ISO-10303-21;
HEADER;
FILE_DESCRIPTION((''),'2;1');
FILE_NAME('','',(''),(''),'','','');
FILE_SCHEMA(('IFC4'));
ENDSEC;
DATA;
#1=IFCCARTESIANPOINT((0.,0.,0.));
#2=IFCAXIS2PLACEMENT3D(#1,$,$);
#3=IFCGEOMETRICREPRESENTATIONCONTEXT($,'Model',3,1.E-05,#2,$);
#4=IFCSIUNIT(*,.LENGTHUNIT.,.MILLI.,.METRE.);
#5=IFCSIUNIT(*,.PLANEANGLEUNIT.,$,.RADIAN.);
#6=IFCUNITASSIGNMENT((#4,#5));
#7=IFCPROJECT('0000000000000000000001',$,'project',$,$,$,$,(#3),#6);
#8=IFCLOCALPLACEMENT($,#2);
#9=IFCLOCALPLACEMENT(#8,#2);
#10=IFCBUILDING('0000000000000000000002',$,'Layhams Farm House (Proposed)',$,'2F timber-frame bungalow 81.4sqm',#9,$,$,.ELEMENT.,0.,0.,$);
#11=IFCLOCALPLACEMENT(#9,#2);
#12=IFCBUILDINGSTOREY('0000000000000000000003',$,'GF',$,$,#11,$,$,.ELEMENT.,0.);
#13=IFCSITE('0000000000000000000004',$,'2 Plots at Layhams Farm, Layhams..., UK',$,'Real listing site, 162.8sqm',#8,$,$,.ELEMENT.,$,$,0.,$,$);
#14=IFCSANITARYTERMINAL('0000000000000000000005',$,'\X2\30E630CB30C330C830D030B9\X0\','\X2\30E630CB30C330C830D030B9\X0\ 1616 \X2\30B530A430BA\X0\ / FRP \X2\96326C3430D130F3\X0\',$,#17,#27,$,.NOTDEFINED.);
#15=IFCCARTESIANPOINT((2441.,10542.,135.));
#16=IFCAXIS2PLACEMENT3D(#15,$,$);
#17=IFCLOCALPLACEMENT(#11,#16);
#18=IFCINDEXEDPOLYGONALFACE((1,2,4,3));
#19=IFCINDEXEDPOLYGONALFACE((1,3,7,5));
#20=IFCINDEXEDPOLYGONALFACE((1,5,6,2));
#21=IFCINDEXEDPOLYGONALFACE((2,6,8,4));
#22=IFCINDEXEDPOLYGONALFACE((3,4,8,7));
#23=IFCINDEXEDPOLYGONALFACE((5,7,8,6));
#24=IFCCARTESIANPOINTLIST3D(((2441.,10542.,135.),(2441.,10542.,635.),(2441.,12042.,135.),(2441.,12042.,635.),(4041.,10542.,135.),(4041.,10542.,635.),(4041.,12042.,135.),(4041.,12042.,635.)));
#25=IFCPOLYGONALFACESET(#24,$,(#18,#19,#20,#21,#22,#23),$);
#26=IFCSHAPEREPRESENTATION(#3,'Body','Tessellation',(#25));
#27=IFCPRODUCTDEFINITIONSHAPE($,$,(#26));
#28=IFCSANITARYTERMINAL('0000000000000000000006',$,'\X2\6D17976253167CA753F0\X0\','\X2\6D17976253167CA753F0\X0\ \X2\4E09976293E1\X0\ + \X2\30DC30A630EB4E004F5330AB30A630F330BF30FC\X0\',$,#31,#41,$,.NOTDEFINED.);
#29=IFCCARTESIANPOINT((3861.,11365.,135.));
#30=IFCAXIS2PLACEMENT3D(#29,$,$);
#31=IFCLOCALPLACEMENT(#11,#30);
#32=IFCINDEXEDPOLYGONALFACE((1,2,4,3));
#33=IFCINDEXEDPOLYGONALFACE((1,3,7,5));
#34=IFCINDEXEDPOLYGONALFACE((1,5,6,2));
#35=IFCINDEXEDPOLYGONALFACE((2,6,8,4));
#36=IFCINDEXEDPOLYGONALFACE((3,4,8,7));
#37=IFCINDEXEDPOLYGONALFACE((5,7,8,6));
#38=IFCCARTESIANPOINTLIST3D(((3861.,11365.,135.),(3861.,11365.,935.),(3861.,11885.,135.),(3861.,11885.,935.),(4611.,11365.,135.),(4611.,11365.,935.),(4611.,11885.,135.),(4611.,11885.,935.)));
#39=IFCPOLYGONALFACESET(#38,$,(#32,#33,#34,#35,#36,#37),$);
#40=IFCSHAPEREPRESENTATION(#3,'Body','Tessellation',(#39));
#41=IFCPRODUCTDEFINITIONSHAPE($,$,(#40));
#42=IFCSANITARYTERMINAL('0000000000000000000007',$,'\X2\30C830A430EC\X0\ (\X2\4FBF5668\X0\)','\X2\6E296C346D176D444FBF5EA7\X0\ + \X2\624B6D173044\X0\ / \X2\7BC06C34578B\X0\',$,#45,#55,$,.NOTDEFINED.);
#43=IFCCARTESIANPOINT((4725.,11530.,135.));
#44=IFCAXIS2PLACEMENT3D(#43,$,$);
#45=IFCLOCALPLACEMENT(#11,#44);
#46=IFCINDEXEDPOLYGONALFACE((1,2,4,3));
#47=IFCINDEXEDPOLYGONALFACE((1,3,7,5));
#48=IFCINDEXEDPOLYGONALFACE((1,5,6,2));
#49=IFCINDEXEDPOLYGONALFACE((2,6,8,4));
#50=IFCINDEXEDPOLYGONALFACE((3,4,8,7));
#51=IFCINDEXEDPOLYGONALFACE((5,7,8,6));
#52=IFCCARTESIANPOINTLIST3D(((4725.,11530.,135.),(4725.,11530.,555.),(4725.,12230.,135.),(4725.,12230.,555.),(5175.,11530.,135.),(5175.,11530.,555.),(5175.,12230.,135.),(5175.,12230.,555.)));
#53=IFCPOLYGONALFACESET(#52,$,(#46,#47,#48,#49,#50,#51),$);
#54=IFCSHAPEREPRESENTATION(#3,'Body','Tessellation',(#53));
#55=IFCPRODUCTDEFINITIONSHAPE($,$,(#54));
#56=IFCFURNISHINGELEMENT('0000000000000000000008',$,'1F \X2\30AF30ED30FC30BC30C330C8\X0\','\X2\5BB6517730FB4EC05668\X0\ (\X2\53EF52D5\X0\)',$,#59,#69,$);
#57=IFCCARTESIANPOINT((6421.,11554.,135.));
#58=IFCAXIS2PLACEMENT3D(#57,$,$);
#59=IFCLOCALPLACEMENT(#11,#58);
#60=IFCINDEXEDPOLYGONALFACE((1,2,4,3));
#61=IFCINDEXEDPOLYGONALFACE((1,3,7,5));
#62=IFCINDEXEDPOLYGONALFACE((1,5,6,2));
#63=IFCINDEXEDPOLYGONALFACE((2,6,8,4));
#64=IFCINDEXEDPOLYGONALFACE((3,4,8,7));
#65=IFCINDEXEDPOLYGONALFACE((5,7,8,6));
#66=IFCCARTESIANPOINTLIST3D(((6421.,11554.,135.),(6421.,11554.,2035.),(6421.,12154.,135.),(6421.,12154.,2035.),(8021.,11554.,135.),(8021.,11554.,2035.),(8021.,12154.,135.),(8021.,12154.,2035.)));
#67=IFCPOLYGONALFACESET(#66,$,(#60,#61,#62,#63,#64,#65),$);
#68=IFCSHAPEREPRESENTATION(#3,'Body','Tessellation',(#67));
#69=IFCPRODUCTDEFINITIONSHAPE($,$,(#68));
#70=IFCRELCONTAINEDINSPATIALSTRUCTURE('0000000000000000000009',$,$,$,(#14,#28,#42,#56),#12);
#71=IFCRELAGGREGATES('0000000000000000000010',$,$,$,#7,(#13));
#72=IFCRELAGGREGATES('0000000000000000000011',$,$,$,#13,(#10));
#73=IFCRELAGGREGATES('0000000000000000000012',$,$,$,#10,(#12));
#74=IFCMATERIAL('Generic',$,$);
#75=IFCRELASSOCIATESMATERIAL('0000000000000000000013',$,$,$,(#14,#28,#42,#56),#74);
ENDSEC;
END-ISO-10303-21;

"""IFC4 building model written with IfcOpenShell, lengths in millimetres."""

from ifc_helpers import new_model, si_unit, frame, frame_2d, origin, place, context, project, spatial, rectangle, extrude, material, element, save


model = new_model("IFC4")

# Units and contexts
model_context = context("Model", 3, precision=1e-05, world=origin())
ifc_project = project(units=[si_unit("LENGTHUNIT", "METRE", prefix="MILLI"), si_unit("PLANEANGLEUNIT", "RADIAN")], contexts=[model_context])

# Site, building, storey
site_placement = place(None, origin())
site = spatial("IfcSite", under=ifc_project, at=site_placement, Name="2 Plots at Layhams Farm, Layhams..., UK", ObjectType="Real listing site, 162.8sqm", CompositionType="ELEMENT", RefElevation=0.0)
building_placement = place(site_placement, origin())
building = spatial("IfcBuilding", under=site, at=building_placement, Name="Layhams Farm House (Proposed)", ObjectType="2F timber-frame bungalow 81.4sqm", CompositionType="ELEMENT", ElevationOfRefHeight=0.0, ElevationOfTerrain=0.0)
storey_placement = place(building_placement, origin())
storey = spatial("IfcBuildingStorey", under=building, at=storey_placement, Name="GF", CompositionType="ELEMENT", Elevation=0.0)

# Shared definitions
ifc_material_1 = material(Name="Generic")

# Sanitary terminals
sanitary_terminal_1_placement = place(storey_placement, frame((2441.0, 10542.0, 135.0)))
element("IfcSanitaryTerminal", 1, at=sanitary_terminal_1_placement, inside=storey, material=ifc_material_1, Name="ユニットバス", Description="ユニットバス 1616 サイズ / FRP 防水パン", PredefinedType="NOTDEFINED", context=model_context, shape_type="SweptSolid", body=[
    extrude(rectangle(XDim=1600.0, YDim=1500.0, at=frame_2d((800.0, 750.0))), frame((2441.0, 10542.0, 135.0)), (0.0, 0.0, 1.0), 500.0),
])
sanitary_terminal_2_placement = place(storey_placement, frame((3861.0, 11365.0, 135.0)))
element("IfcSanitaryTerminal", 2, at=sanitary_terminal_2_placement, inside=storey, material=ifc_material_1, Name="洗面化粧台", Description="洗面化粧台 三面鏡 + ボウル一体カウンター", PredefinedType="NOTDEFINED", context=model_context, shape_type="SweptSolid", body=[
    extrude(rectangle(XDim=750.0, YDim=520.0, at=frame_2d((375.0, 260.0))), frame((3861.0, 11365.0, 135.0)), (0.0, 0.0, 1.0), 800.0),
])
sanitary_terminal_3_placement = place(storey_placement, frame((4725.0, 11530.0, 135.0)))
element("IfcSanitaryTerminal", 3, at=sanitary_terminal_3_placement, inside=storey, material=ifc_material_1, Name="トイレ (便器)", Description="温水洗浄便座 + 手洗い / 節水型", PredefinedType="NOTDEFINED", context=model_context, shape_type="SweptSolid", body=[
    extrude(rectangle(XDim=450.0, YDim=700.0, at=frame_2d((225.0, 350.0))), frame((4725.0, 11530.0, 135.0)), (0.0, 0.0, 1.0), 420.0),
])

# Furnishing element
furnishing_placement = place(storey_placement, frame((6421.0, 11554.0, 135.0)))
element("IfcFurnishingElement", 4, at=furnishing_placement, inside=storey, material=ifc_material_1, Name="1F クローゼット", Description="家具・什器 (可動)", context=model_context, shape_type="SweptSolid", body=[
    extrude(rectangle(XDim=1600.0, YDim=600.0, at=frame_2d((800.0, 300.0))), frame((6421.0, 11554.0, 135.0)), (0.0, 0.0, 1.0), 1900.0),
])

save(model, "model.ifc")
